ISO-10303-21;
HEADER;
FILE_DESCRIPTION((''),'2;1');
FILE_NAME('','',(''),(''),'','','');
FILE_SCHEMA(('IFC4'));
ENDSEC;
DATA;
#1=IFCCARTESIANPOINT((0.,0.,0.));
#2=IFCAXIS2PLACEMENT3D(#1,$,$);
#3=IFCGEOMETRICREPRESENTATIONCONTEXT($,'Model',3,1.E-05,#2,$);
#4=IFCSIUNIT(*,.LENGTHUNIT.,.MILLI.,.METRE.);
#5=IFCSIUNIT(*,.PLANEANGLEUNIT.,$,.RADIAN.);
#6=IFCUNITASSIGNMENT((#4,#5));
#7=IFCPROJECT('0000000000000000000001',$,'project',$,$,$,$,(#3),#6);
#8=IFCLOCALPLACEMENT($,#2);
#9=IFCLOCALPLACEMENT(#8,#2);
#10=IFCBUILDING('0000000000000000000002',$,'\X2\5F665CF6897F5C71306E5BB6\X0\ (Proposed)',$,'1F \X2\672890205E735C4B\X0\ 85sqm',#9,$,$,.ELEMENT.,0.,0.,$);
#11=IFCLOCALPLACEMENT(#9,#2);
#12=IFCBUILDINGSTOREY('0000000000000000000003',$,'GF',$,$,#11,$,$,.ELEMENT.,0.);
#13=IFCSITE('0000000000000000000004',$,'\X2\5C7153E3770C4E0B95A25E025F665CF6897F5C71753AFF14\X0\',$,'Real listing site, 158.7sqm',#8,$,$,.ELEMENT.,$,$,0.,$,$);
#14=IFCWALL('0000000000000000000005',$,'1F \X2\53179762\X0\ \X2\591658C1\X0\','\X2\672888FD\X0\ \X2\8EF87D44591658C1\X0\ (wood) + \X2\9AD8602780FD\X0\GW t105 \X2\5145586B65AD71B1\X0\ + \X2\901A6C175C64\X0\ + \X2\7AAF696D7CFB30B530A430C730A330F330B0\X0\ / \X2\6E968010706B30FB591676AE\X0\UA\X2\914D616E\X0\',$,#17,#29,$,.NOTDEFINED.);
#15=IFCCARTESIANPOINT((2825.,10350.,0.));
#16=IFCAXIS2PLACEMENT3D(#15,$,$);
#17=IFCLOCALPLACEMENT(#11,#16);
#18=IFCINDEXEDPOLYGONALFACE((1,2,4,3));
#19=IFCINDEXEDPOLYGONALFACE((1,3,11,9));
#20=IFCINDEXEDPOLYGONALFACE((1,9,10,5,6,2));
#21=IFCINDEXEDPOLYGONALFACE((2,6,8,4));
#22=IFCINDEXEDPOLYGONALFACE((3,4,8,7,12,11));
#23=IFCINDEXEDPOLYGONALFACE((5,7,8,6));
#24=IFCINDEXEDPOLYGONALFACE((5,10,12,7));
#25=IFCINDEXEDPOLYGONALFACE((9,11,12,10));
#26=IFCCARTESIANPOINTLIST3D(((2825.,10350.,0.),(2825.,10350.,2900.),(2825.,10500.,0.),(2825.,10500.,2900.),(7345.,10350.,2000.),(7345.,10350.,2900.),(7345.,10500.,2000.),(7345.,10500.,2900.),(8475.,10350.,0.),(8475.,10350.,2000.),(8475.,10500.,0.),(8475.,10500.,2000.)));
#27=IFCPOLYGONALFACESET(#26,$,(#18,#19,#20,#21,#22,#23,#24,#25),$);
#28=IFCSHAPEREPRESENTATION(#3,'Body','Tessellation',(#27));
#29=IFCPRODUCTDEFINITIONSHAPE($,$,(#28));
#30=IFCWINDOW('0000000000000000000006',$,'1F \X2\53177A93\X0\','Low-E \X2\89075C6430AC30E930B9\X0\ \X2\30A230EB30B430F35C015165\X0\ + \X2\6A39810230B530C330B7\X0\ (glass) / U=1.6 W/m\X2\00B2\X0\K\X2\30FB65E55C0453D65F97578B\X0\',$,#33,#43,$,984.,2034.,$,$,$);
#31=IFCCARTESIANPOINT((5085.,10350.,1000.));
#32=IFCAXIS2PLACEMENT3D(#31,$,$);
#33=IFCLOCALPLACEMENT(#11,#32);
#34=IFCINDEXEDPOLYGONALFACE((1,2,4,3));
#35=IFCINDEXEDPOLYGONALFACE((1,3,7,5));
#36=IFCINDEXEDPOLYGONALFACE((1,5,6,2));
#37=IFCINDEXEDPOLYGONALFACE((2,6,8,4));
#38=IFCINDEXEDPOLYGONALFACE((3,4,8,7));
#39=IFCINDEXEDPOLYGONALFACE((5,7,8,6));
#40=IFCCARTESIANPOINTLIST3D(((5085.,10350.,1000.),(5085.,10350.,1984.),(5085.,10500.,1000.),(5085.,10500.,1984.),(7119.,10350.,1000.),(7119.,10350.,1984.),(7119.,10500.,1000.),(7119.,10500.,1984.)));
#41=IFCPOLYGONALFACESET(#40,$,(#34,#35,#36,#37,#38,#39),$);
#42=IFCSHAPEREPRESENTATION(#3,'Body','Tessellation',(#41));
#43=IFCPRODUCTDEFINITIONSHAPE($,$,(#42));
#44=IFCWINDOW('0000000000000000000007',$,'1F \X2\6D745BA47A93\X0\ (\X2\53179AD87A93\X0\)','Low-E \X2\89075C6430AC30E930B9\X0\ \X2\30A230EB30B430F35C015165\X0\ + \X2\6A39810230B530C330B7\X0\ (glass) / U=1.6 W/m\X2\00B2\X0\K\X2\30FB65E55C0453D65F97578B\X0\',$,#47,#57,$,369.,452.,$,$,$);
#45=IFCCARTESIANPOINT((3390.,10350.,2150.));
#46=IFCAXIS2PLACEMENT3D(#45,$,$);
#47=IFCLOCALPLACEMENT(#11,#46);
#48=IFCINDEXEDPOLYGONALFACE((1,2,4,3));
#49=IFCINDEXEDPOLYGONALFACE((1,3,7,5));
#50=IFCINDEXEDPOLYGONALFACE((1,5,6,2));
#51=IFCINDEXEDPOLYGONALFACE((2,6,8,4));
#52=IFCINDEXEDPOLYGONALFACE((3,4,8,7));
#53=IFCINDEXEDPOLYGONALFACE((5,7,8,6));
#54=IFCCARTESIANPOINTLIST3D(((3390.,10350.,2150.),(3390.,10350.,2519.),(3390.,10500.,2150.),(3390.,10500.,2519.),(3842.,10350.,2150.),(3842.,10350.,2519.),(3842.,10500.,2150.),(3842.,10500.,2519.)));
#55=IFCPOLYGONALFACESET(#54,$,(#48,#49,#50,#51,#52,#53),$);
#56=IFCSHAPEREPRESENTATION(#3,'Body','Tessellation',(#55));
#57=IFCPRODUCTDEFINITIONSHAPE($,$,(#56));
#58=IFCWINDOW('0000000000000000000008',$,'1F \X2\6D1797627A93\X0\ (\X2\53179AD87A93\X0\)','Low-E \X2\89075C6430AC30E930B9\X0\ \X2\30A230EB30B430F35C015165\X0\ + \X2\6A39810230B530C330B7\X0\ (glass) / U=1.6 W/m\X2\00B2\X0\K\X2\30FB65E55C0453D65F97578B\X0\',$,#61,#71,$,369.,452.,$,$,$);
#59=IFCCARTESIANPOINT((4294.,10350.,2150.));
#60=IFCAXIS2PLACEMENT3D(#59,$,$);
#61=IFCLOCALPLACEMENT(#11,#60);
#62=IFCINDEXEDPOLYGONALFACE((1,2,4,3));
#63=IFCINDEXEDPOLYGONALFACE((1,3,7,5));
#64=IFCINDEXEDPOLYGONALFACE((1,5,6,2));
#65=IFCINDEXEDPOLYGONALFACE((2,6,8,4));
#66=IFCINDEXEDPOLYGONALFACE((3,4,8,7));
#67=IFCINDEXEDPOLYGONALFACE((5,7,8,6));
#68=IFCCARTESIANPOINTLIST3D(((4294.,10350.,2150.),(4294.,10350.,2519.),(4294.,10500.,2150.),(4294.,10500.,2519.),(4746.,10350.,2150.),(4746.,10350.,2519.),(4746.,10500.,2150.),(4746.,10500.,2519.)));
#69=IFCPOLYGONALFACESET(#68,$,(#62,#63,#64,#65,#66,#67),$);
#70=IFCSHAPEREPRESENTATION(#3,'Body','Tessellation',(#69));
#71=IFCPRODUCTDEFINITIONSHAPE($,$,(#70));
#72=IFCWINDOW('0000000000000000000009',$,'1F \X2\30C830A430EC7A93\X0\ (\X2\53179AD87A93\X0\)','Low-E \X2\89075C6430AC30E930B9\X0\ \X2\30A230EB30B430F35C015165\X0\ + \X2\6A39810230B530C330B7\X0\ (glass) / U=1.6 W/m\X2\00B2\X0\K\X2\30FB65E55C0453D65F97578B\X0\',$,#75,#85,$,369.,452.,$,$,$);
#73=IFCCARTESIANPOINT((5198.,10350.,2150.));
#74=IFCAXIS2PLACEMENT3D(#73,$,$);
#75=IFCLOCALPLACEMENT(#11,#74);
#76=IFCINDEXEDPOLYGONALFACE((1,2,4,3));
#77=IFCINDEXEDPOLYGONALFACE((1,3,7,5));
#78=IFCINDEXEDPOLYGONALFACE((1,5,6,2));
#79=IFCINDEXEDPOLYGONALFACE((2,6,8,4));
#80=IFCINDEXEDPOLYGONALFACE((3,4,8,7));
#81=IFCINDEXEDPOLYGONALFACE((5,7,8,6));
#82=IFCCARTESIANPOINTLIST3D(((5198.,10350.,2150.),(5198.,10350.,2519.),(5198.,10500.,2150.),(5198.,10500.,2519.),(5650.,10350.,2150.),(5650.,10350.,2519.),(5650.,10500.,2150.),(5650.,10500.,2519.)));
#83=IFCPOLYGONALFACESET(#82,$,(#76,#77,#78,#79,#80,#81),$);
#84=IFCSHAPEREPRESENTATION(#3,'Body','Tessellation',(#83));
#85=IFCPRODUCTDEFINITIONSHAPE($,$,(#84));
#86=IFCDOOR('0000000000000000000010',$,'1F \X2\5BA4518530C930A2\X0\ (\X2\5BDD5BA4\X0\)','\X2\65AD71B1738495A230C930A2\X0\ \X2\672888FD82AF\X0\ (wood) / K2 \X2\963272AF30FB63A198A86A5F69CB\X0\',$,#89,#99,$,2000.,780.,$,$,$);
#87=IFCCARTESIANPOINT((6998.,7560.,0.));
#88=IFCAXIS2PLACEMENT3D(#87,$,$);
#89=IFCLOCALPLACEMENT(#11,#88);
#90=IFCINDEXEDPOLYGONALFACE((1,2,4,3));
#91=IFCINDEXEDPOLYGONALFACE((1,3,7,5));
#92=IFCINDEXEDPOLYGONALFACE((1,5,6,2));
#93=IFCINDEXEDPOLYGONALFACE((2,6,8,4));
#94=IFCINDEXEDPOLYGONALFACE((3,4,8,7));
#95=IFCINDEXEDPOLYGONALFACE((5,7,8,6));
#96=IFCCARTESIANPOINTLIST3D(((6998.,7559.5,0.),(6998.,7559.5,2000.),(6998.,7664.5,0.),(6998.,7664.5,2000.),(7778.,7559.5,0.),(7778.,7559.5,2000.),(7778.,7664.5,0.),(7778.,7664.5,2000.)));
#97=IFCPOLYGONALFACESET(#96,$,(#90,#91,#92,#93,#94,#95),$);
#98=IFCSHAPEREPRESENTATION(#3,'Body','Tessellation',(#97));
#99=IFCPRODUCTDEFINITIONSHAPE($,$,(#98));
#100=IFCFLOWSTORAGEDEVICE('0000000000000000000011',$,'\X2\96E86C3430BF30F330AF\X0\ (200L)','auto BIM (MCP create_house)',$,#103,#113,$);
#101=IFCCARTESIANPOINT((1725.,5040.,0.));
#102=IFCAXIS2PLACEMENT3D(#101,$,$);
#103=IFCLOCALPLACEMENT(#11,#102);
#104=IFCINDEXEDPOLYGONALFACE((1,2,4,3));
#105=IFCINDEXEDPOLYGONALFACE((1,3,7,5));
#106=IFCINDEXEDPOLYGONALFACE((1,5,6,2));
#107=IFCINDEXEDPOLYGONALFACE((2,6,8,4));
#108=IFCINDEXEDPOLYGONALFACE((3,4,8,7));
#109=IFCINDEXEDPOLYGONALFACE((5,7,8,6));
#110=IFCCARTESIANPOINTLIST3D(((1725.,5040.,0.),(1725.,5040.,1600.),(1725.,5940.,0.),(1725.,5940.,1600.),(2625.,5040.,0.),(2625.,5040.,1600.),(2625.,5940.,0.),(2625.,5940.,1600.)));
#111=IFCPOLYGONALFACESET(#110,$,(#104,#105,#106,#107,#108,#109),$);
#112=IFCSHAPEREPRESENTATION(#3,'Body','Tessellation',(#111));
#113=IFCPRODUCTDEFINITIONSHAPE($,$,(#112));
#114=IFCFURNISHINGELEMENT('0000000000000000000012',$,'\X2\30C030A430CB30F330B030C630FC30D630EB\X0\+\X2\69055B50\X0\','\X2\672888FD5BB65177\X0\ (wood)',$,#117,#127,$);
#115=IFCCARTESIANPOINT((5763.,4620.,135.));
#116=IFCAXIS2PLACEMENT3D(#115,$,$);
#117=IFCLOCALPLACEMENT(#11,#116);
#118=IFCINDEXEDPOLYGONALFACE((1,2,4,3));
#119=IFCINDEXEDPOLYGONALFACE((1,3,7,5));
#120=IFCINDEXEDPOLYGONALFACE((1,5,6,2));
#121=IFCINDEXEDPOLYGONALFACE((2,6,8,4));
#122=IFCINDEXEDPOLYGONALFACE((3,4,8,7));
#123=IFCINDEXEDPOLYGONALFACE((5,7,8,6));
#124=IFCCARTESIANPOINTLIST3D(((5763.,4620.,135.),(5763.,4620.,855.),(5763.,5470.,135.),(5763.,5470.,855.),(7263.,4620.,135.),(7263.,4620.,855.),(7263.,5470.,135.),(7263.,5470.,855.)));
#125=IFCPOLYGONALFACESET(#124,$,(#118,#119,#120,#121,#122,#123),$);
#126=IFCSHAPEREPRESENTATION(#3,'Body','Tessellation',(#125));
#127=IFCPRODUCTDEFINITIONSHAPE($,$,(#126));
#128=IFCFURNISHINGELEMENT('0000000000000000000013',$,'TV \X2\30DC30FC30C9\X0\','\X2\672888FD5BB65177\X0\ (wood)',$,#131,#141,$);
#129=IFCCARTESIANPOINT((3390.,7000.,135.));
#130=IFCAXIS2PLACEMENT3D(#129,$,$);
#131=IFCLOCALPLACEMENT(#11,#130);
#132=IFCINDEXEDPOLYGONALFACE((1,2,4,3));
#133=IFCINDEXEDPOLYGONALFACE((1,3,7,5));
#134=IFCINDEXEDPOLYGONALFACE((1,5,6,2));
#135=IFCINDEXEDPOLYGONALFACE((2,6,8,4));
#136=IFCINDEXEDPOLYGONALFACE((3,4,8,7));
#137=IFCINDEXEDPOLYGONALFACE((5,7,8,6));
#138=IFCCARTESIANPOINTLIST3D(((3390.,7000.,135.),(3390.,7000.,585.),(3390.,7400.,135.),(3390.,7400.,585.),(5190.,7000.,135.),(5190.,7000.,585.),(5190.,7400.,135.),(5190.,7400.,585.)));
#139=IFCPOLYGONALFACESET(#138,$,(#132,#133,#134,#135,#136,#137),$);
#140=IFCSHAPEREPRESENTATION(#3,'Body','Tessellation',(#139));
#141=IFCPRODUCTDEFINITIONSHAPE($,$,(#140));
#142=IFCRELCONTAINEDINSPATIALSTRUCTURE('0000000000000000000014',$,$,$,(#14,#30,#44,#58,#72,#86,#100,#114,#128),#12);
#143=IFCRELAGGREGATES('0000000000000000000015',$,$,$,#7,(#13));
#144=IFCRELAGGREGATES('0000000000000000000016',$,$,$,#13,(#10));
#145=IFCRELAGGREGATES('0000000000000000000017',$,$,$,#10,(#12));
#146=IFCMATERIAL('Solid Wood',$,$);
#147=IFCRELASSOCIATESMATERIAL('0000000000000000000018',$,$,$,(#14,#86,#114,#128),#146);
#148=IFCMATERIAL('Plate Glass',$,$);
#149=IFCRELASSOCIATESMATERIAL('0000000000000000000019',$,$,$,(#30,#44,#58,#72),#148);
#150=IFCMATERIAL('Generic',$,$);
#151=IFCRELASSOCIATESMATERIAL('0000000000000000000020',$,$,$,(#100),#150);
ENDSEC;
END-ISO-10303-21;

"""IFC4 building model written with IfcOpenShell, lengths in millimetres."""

from ifc_helpers import new_model, si_unit, frame, frame_2d, origin, place, context, project, spatial, rectangle, extrude, material, element, fill, save


model = new_model("IFC4")

# Units and contexts
model_context = context("Model", 3, precision=1e-05, world=origin())
ifc_project = project(units=[si_unit("LENGTHUNIT", "METRE", prefix="MILLI"), si_unit("PLANEANGLEUNIT", "RADIAN")], contexts=[model_context])

# Site, building, storey
site_placement = place(None, origin())
site = spatial("IfcSite", under=ifc_project, at=site_placement, Name="山口県下関市彦島西山町４", ObjectType="Real listing site, 158.7sqm", CompositionType="ELEMENT", RefElevation=0.0)
building_placement = place(site_placement, origin())
building = spatial("IfcBuilding", under=site, at=building_placement, Name="彦島西山の家 (Proposed)", ObjectType="1F 木造平屋 85sqm", CompositionType="ELEMENT", ElevationOfRefHeight=0.0, ElevationOfTerrain=0.0)
storey_placement = place(building_placement, origin())
storey = spatial("IfcBuildingStorey", under=building, at=storey_placement, Name="GF", CompositionType="ELEMENT", Elevation=0.0)

# Wall, openings, windows
ifc_material_1 = material(Name="Solid Wood")
wall_1_placement = place(storey_placement, frame((2825.0, 10350.0, 0.0)))
wall_1 = element("IfcWall", 1, at=wall_1_placement, inside=storey, material=ifc_material_1, Name="1F 北面 外壁", Description="木製 軸組外壁 (wood) + 高性能GW t105 充填断熱 + 通気層 + 窯業系サイディング / 準耐火・外皮UA配慮", PredefinedType="NOTDEFINED", context=model_context, shape_type="SweptSolid", body=[
    extrude(rectangle(XDim=5650.0, YDim=150.0, at=frame_2d((2825.0, 75.0))), frame((2825.0, 10350.0, 0.0)), (0.0, 0.0, 1.0), 2900.0),
])
opening_1_placement = place(storey_placement, frame((5085.0, 10350.0, 1000.0)))
opening_1 = element("IfcOpeningElement", 2, at=opening_1_placement, cuts=wall_1, PredefinedType="NOTDEFINED", context=model_context, shape_type="SweptSolid", body=[
    extrude(rectangle(XDim=2034.0, YDim=150.0, at=frame_2d((1017.0, 75.0))), frame((5085.0, 10350.0, 1000.0)), (0.0, 0.0, 1.0), 984.0),
])
opening_2_placement = place(storey_placement, frame((3390.0, 10350.0, 2150.0)))
opening_2 = element("IfcOpeningElement", 3, at=opening_2_placement, cuts=wall_1, PredefinedType="NOTDEFINED", context=model_context, shape_type="SweptSolid", body=[
    extrude(rectangle(XDim=452.0, YDim=150.0, at=frame_2d((226.0, 75.0))), frame((3390.0, 10350.0, 2150.0)), (0.0, 0.0, 1.0), 369.0),
])
opening_3_placement = place(storey_placement, frame((4294.0, 10350.0, 2150.0)))
opening_3 = element("IfcOpeningElement", 4, at=opening_3_placement, cuts=wall_1, PredefinedType="NOTDEFINED", context=model_context, shape_type="SweptSolid", body=[
    extrude(rectangle(XDim=452.0, YDim=150.0, at=frame_2d((226.0, 75.0))), frame((4294.0, 10350.0, 2150.0)), (0.0, 0.0, 1.0), 369.0),
])
opening_4_placement = place(storey_placement, frame((5198.0, 10350.0, 2150.0)))
opening_4 = element("IfcOpeningElement", 5, at=opening_4_placement, cuts=wall_1, PredefinedType="NOTDEFINED", context=model_context, shape_type="SweptSolid", body=[
    extrude(rectangle(XDim=452.0, YDim=150.0, at=frame_2d((226.0, 75.0))), frame((5198.0, 10350.0, 2150.0)), (0.0, 0.0, 1.0), 369.0),
])
ifc_material_2 = material(Name="Plate Glass")
window_1_placement = place(storey_placement, frame((5085.0, 10350.0, 1000.0)))
window_1 = element("IfcWindow", 6, at=window_1_placement, inside=storey, material=ifc_material_2, Name="1F 北窓", Description="Low-E 複層ガラス アルゴン封入 + 樹脂サッシ (glass) / U=1.6 W/m²K・日射取得型", OverallHeight=984.0, OverallWidth=2034.0, context=model_context, shape_type="SweptSolid", body=[
    extrude(rectangle(XDim=2034.0, YDim=150.0, at=frame_2d((1017.0, 75.0))), frame((5085.0, 10350.0, 1000.0)), (0.0, 0.0, 1.0), 984.0),
])
fill(opening_1, window_1)
window_2_placement = place(storey_placement, frame((3390.0, 10350.0, 2150.0)))
window_2 = element("IfcWindow", 7, at=window_2_placement, inside=storey, material=ifc_material_2, Name="1F 浴室窓 (北高窓)", Description="Low-E 複層ガラス アルゴン封入 + 樹脂サッシ (glass) / U=1.6 W/m²K・日射取得型", OverallHeight=369.0, OverallWidth=452.0, context=model_context, shape_type="SweptSolid", body=[
    extrude(rectangle(XDim=452.0, YDim=150.0, at=frame_2d((226.0, 75.0))), frame((3390.0, 10350.0, 2150.0)), (0.0, 0.0, 1.0), 369.0),
])
fill(opening_2, window_2)
window_3_placement = place(storey_placement, frame((4294.0, 10350.0, 2150.0)))
window_3 = element("IfcWindow", 8, at=window_3_placement, inside=storey, material=ifc_material_2, Name="1F 洗面窓 (北高窓)", Description="Low-E 複層ガラス アルゴン封入 + 樹脂サッシ (glass) / U=1.6 W/m²K・日射取得型", OverallHeight=369.0, OverallWidth=452.0, context=model_context, shape_type="SweptSolid", body=[
    extrude(rectangle(XDim=452.0, YDim=150.0, at=frame_2d((226.0, 75.0))), frame((4294.0, 10350.0, 2150.0)), (0.0, 0.0, 1.0), 369.0),
])
fill(opening_3, window_3)
window_4_placement = place(storey_placement, frame((5198.0, 10350.0, 2150.0)))
window_4 = element("IfcWindow", 9, at=window_4_placement, inside=storey, material=ifc_material_2, Name="1F トイレ窓 (北高窓)", Description="Low-E 複層ガラス アルゴン封入 + 樹脂サッシ (glass) / U=1.6 W/m²K・日射取得型", OverallHeight=369.0, OverallWidth=452.0, context=model_context, shape_type="SweptSolid", body=[
    extrude(rectangle(XDim=452.0, YDim=150.0, at=frame_2d((226.0, 75.0))), frame((5198.0, 10350.0, 2150.0)), (0.0, 0.0, 1.0), 369.0),
])
fill(opening_4, window_4)

# Door
door_1_placement = place(storey_placement, frame((6998.0, 7560.0, 0.0)))
element("IfcDoor", 10, at=door_1_placement, inside=storey, material=ifc_material_1, Name="1F 室内ドア (寝室)", Description="断熱玄関ドア 木製芯 (wood) / K2 防犯・採風機構", OverallHeight=2000.0, OverallWidth=780.0, context=model_context, shape_type="SweptSolid", body=[
    extrude(rectangle(XDim=780.0, YDim=105.0, at=frame_2d((390.0, 52.0))), frame((6998.0, 7560.0, 0.0)), (0.0, 0.0, 1.0), 2000.0),
])

# Flow storage device
ifc_material_3 = material(Name="Generic")
flow_storage_device_placement = place(storey_placement, frame((1725.0, 5040.0, 0.0)))
element("IfcFlowStorageDevice", 11, at=flow_storage_device_placement, inside=storey, material=ifc_material_3, Name="雨水タンク (200L)", Description="auto BIM (MCP create_house)", context=model_context, shape_type="SweptSolid", body=[
    extrude(rectangle(XDim=900.0, YDim=900.0, at=frame_2d((450.0, 450.0))), frame((1725.0, 5040.0, 0.0)), (0.0, 0.0, 1.0), 1600.0),
])

# Furnishing elements
furnishing_1_placement = place(storey_placement, frame((5763.0, 4620.0, 135.0)))
element("IfcFurnishingElement", 12, at=furnishing_1_placement, inside=storey, material=ifc_material_1, Name="ダイニングテーブル+椅子", Description="木製家具 (wood)", context=model_context, shape_type="SweptSolid", body=[
    extrude(rectangle(XDim=1500.0, YDim=850.0, at=frame_2d((750.0, 425.0))), frame((5763.0, 4620.0, 135.0)), (0.0, 0.0, 1.0), 720.0),
])
furnishing_2_placement = place(storey_placement, frame((3390.0, 7000.0, 135.0)))
element("IfcFurnishingElement", 13, at=furnishing_2_placement, inside=storey, material=ifc_material_1, Name="TV ボード", Description="木製家具 (wood)", context=model_context, shape_type="SweptSolid", body=[
    extrude(rectangle(XDim=1800.0, YDim=400.0, at=frame_2d((900.0, 200.0))), frame((3390.0, 7000.0, 135.0)), (0.0, 0.0, 1.0), 450.0),
])

save(model, "model.ifc")
